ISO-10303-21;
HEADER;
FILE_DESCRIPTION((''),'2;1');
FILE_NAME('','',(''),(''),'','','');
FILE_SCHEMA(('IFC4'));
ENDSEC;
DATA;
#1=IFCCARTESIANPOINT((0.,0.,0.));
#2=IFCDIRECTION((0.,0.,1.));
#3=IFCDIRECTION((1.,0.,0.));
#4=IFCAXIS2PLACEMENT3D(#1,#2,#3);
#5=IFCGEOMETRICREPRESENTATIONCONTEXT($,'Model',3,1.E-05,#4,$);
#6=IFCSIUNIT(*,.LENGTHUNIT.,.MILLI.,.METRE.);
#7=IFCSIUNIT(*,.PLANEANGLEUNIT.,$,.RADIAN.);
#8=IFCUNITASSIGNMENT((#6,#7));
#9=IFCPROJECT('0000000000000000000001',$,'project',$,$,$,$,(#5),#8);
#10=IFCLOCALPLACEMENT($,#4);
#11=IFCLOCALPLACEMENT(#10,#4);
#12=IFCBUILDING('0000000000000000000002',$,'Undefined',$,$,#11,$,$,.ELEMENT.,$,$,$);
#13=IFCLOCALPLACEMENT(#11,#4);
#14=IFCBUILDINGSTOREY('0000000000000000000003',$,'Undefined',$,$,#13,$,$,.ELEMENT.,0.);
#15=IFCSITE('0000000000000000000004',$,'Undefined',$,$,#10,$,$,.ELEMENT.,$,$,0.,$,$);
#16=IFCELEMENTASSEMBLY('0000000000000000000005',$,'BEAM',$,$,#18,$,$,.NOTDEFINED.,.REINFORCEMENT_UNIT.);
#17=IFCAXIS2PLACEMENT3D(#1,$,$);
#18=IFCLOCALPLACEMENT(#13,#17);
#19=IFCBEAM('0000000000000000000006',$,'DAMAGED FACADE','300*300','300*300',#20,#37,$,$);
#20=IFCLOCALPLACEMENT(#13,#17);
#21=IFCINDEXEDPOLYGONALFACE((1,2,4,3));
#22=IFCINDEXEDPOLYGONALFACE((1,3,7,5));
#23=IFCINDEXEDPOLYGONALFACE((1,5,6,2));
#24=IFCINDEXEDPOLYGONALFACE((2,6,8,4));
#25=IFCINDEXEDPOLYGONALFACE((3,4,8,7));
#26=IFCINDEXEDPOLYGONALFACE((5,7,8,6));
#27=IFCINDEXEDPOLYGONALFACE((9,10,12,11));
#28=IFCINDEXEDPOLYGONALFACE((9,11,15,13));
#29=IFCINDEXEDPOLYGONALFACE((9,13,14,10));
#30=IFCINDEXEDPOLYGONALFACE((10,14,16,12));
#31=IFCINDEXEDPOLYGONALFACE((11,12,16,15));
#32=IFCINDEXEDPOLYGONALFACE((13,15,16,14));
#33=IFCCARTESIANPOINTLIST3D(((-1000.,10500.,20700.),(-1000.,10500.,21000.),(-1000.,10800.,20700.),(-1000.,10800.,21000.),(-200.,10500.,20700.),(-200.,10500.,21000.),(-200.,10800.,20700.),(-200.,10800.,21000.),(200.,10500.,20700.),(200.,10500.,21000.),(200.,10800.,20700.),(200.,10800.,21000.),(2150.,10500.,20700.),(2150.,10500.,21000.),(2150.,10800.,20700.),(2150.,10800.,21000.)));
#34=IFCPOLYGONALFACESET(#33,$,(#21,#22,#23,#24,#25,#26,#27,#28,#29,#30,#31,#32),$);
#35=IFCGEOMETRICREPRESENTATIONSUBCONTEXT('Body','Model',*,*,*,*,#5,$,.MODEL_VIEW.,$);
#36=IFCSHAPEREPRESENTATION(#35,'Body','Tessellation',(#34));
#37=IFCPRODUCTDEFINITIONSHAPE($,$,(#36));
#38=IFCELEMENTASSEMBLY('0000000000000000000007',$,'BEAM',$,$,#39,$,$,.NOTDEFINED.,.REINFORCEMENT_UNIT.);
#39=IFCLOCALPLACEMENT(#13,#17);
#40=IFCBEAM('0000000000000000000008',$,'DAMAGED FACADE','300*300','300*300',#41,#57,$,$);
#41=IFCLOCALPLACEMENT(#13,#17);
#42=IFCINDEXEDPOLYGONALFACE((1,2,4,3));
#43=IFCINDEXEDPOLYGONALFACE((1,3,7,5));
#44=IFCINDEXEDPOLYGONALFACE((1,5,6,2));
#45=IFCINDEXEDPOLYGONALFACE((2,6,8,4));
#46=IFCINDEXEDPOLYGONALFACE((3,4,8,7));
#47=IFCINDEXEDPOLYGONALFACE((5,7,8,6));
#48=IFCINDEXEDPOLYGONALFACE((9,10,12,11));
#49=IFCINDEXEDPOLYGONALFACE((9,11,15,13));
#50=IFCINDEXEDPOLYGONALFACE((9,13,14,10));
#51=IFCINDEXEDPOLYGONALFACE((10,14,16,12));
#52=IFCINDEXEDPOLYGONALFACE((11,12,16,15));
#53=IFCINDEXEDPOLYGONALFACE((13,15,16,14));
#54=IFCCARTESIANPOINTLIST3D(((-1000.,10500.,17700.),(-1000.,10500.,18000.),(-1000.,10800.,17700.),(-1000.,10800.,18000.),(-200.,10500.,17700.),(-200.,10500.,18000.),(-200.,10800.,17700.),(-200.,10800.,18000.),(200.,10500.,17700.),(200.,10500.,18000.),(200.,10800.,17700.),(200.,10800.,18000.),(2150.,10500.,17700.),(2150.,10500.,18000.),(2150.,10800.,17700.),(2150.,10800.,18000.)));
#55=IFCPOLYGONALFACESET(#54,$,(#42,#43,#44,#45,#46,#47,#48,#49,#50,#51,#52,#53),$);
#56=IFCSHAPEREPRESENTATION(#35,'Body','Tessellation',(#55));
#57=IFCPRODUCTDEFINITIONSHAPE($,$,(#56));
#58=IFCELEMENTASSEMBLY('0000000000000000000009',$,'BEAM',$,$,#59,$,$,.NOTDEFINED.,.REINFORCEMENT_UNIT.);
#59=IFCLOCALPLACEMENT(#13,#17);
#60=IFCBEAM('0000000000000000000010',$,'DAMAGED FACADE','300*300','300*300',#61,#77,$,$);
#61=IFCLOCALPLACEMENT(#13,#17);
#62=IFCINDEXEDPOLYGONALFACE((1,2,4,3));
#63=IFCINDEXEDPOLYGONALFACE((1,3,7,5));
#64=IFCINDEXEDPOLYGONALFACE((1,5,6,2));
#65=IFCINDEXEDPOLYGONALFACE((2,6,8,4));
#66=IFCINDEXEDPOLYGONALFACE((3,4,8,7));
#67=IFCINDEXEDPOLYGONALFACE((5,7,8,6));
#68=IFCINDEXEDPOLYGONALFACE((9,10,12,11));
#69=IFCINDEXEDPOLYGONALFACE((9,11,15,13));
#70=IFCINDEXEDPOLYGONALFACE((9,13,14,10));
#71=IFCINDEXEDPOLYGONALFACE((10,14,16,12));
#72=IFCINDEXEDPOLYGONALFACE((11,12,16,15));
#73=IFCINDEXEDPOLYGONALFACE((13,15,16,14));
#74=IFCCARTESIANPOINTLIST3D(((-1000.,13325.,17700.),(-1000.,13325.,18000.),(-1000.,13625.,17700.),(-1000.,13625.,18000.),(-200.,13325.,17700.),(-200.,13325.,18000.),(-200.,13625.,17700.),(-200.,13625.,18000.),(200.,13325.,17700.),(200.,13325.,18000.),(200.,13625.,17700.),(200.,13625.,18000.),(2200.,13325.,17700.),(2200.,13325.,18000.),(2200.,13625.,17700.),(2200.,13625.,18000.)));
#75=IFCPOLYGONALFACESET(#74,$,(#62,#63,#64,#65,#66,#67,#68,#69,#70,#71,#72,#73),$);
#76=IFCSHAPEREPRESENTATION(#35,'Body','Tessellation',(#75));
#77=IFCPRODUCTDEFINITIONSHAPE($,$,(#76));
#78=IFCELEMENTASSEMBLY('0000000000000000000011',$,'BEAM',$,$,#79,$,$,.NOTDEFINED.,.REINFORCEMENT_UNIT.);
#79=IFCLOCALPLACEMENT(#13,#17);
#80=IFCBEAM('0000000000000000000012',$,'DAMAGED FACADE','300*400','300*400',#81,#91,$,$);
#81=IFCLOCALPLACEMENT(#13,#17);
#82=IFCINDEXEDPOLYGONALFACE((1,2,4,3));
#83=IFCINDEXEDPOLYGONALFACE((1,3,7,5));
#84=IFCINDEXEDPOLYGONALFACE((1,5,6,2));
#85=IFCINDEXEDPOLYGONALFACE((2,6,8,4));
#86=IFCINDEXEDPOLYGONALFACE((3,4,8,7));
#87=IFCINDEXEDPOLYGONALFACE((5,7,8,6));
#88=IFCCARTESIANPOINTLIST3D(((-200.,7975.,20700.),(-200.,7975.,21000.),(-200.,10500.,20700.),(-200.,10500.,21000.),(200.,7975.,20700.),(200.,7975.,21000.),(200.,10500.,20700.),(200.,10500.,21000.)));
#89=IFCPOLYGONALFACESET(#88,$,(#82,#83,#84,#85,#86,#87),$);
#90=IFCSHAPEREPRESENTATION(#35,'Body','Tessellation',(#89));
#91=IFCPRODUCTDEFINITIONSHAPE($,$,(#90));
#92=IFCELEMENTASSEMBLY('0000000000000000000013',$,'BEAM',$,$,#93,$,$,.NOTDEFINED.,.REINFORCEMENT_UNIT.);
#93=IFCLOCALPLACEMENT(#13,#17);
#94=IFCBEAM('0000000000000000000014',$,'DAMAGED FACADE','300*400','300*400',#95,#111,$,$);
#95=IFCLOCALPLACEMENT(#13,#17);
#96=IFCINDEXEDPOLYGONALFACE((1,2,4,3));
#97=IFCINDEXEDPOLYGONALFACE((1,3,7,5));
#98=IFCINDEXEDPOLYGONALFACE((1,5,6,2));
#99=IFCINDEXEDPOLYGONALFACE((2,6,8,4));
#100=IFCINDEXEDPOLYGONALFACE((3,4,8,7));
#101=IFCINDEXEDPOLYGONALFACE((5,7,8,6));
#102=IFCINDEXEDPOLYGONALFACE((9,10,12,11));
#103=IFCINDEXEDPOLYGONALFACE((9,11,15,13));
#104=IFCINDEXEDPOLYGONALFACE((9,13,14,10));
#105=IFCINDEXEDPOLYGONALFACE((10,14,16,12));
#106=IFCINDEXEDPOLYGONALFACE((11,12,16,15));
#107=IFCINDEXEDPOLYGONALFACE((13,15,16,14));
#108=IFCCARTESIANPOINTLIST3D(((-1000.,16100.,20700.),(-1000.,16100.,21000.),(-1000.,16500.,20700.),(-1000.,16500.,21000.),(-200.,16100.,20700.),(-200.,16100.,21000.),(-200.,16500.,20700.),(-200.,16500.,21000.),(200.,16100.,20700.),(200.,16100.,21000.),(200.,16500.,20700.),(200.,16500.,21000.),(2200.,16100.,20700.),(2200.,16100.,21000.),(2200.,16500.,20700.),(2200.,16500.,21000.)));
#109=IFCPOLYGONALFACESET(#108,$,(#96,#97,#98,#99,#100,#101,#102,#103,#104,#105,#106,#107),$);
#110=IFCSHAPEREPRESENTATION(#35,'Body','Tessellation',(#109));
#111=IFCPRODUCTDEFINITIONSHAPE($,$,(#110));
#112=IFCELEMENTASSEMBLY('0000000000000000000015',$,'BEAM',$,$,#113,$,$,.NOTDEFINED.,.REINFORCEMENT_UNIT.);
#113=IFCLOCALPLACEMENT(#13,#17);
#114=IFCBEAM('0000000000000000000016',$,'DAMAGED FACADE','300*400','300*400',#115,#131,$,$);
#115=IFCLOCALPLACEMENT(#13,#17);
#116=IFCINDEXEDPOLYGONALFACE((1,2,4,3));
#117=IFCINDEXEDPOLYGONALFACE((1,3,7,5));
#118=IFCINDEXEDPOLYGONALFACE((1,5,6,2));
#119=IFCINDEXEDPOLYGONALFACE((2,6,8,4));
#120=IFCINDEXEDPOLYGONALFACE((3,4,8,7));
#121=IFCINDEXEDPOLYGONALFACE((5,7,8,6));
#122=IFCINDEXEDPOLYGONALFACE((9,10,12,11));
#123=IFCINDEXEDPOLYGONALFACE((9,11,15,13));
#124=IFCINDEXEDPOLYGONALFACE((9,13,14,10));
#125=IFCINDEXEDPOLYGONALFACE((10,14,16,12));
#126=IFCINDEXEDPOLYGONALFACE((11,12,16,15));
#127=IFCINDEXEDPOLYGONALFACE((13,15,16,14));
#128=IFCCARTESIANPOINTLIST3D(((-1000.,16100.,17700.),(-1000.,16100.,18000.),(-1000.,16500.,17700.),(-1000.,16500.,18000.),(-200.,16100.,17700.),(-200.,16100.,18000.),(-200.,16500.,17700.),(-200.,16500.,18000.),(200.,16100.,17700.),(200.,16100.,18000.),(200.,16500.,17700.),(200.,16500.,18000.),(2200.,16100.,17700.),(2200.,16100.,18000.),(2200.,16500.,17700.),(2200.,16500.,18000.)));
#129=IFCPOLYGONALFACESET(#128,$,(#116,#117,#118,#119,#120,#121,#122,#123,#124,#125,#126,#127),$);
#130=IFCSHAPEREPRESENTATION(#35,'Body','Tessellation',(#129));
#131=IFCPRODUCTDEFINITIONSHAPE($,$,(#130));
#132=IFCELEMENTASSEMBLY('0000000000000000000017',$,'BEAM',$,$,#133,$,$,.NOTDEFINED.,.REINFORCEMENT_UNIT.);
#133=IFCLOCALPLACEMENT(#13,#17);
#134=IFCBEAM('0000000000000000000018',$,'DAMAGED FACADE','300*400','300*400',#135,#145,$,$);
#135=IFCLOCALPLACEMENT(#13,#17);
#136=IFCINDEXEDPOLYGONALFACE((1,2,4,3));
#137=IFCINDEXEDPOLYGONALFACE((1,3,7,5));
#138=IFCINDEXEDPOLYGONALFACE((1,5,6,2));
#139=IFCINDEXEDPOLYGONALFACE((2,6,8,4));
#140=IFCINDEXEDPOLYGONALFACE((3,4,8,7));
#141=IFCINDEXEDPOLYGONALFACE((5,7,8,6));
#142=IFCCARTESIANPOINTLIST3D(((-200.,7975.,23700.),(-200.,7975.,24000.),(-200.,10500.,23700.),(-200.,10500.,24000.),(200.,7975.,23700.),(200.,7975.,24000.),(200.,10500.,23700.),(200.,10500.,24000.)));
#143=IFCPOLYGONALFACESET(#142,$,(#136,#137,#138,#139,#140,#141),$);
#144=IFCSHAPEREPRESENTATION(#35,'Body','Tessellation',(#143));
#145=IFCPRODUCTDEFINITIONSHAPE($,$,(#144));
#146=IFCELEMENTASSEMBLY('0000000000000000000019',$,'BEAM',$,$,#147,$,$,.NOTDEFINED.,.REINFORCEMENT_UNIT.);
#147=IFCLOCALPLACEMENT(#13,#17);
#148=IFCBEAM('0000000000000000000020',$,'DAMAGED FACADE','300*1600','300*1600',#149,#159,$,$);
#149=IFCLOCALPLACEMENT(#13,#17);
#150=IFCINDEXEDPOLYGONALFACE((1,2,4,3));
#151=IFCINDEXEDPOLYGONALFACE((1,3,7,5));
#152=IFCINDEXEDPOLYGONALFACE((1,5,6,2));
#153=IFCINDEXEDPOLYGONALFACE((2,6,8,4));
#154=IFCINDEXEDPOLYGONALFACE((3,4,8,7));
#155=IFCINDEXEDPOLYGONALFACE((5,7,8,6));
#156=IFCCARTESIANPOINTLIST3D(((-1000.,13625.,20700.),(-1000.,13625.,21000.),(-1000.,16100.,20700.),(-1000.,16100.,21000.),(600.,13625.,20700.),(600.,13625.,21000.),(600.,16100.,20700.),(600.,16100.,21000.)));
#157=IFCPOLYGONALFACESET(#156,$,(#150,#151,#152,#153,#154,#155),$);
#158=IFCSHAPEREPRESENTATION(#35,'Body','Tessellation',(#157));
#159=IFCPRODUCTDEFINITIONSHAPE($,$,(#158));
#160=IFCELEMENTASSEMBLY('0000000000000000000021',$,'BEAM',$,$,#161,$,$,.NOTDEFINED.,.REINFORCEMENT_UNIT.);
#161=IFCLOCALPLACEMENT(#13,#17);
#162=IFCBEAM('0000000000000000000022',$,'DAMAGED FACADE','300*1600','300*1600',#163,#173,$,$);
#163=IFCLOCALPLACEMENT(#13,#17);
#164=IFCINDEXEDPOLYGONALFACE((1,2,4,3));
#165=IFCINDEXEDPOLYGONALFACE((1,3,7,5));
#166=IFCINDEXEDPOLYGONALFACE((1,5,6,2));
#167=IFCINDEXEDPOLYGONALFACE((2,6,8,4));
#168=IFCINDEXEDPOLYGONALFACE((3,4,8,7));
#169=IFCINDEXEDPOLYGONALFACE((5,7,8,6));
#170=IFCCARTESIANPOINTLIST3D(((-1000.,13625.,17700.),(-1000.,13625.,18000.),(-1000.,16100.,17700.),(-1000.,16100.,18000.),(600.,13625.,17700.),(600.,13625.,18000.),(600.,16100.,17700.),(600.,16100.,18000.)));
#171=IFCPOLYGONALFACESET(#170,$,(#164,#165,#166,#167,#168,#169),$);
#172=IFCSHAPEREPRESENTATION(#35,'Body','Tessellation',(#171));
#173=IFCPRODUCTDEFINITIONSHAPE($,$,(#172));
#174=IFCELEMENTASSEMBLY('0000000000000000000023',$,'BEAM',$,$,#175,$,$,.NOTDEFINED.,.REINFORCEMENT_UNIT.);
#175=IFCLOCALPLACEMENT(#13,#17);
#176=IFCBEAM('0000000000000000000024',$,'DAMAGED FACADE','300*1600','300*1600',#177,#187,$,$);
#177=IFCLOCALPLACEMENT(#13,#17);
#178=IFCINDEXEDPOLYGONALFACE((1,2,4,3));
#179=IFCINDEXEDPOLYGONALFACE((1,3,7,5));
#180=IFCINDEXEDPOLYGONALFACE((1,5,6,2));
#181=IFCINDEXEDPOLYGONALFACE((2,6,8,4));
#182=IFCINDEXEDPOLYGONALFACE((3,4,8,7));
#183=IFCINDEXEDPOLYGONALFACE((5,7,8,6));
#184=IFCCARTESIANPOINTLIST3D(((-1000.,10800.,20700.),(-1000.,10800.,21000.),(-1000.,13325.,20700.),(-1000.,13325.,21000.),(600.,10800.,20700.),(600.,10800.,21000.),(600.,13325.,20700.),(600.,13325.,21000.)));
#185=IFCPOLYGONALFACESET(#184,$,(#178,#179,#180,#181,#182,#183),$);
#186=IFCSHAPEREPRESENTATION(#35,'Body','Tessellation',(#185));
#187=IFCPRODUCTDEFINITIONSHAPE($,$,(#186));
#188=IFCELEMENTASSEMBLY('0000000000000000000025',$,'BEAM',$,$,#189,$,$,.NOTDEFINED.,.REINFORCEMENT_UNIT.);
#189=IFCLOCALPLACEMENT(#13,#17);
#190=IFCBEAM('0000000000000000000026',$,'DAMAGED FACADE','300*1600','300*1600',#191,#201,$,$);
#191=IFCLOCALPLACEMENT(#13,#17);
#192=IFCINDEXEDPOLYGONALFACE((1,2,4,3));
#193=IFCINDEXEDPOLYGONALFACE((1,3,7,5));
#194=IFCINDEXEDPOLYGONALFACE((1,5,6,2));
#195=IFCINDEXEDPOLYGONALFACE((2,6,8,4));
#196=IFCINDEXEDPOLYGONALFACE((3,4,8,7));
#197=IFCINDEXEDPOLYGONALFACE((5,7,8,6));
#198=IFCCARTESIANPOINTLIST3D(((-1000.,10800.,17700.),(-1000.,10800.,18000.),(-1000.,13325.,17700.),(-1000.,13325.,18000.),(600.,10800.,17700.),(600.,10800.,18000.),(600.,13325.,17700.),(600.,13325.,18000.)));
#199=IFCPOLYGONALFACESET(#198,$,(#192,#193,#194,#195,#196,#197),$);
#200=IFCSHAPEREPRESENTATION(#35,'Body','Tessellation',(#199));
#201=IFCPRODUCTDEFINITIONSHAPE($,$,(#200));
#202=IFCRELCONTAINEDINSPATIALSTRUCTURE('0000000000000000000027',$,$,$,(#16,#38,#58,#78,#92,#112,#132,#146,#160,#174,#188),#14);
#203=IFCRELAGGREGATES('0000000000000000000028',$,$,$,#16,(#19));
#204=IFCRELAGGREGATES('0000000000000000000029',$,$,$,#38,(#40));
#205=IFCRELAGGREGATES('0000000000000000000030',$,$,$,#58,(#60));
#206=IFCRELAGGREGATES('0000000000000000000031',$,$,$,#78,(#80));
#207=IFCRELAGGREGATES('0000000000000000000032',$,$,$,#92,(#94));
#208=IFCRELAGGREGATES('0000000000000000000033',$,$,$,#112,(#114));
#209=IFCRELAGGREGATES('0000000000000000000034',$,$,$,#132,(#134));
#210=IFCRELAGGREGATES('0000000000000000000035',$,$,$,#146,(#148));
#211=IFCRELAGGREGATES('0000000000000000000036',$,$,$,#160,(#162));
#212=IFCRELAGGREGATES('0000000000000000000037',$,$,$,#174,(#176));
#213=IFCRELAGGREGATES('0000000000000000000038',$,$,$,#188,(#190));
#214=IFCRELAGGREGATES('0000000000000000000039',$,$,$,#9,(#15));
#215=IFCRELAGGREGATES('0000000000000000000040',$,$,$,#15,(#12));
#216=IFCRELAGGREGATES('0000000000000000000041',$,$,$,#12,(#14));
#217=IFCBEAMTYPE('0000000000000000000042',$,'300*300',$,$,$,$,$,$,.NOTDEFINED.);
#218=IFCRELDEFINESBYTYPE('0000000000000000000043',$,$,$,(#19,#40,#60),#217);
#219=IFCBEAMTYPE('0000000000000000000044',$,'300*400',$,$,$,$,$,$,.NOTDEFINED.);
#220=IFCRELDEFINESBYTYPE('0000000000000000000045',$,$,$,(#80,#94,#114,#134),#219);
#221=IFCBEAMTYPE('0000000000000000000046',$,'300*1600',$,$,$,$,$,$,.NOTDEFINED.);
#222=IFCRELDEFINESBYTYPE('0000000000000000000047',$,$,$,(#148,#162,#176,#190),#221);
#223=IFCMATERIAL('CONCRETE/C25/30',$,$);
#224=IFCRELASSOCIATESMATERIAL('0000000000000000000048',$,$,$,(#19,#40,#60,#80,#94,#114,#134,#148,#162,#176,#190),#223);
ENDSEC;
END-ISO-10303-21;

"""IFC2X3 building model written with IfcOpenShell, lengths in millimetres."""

from ifc_helpers import new_model, si_unit, frame, origin_with_axes, origin_2d_with_axis, place, context, subcontext, project, spatial, rectangle, extrude, boolean, material, type_object, element, aggregate, save


model = new_model("IFC2X3")

# Units and contexts
model_context = context("Model", 3, precision=1e-05, world=origin_with_axes())
body_context = subcontext(model_context, "Body", "Model", "MODEL_VIEW")
ifc_project = project(units=[si_unit("LENGTHUNIT", "METRE", prefix="MILLI"), si_unit("PLANEANGLEUNIT", "RADIAN")], contexts=[model_context])

# Site, building, storey
site_placement = place(None, origin_with_axes())
site = spatial("IfcSite", under=ifc_project, at=site_placement, Name="Undefined", CompositionType="ELEMENT", RefElevation=0.0)
building_placement = place(site_placement, origin_with_axes())
building = spatial("IfcBuilding", under=site, at=building_placement, Name="Undefined", CompositionType="ELEMENT")
storey_placement = place(building_placement, origin_with_axes())
storey = spatial("IfcBuildingStorey", under=building, at=storey_placement, Name="Undefined", CompositionType="ELEMENT", Elevation=0.0)

# Shared definitions
ifc_material = material(Name="CONCRETE/C25/30")

# Element assemblies, beams
beam_type_1 = type_object("IfcBeamType", Name="300*300", PredefinedType="NOTDEFINED")
assembly_1_placement = place(storey_placement, origin_with_axes())
assembly_1 = element("IfcElementAssembly", 1, at=assembly_1_placement, inside=storey, Name="BEAM", AssemblyPlace="NOTDEFINED", PredefinedType="REINFORCEMENT_UNIT")
beam_1_placement = place(assembly_1_placement, frame((2150.0, 10650.0, 20850.0), z_axis=(0.0, 0.0, 1.0), x_axis=(-1.0, 0.0, 0.0)))
beam_1 = element("IfcBeam", 2, at=beam_1_placement, type_object=beam_type_1, material=ifc_material, Name="DAMAGED FACADE", Description="300*300", ObjectType="300*300", context=body_context, shape_type="CSG", body=[
    boolean("DIFFERENCE", extrude(rectangle(XDim=300.0, YDim=300.0, at=origin_2d_with_axis()), frame((3150.0, 0.0, 0.0), z_axis=(-1.0, 0.0, 0.0), x_axis=(0.0, -1.0, 0.0)), (0.0, 0.0, 1.0), 3150.0), extrude(rectangle(XDim=400.0, YDim=300.0, at=origin_2d_with_axis()), frame((2150.0, 0.0, 150.0), z_axis=(0.0, 0.0, -1.0), x_axis=(1.0, 0.0, 0.0)), (0.0, 0.0, 1.0), 3000.0)),
])
aggregate(assembly_1, [beam_1])
assembly_2_placement = place(storey_placement, origin_with_axes())
assembly_2 = element("IfcElementAssembly", 3, at=assembly_2_placement, inside=storey, Name="BEAM", AssemblyPlace="NOTDEFINED", PredefinedType="REINFORCEMENT_UNIT")
beam_2_placement = place(assembly_2_placement, frame((2150.0, 10650.0, 17850.0), z_axis=(0.0, 0.0, 1.0), x_axis=(-1.0, 0.0, 0.0)))
beam_2 = element("IfcBeam", 4, at=beam_2_placement, type_object=beam_type_1, material=ifc_material, Name="DAMAGED FACADE", Description="300*300", ObjectType="300*300", context=body_context, shape_type="CSG", body=[
    boolean("DIFFERENCE", extrude(rectangle(XDim=300.0, YDim=300.0, at=origin_2d_with_axis()), frame((3150.0, 0.0, 0.0), z_axis=(-1.0, 0.0, 0.0), x_axis=(0.0, -1.0, 0.0)), (0.0, 0.0, 1.0), 3150.0), extrude(rectangle(XDim=400.0, YDim=300.0, at=origin_2d_with_axis()), frame((2150.0, 0.0, 150.0), z_axis=(0.0, 0.0, -1.0), x_axis=(1.0, 0.0, 0.0)), (0.0, 0.0, 1.0), 3000.0)),
])
aggregate(assembly_2, [beam_2])
assembly_3_placement = place(storey_placement, origin_with_axes())
assembly_3 = element("IfcElementAssembly", 5, at=assembly_3_placement, inside=storey, Name="BEAM", AssemblyPlace="NOTDEFINED", PredefinedType="REINFORCEMENT_UNIT")
beam_3_placement = place(assembly_3_placement, frame((2200.0, 13475.0, 17850.0), z_axis=(0.0, 0.0, 1.0), x_axis=(-1.0, 0.0, 0.0)))
beam_3 = element("IfcBeam", 6, at=beam_3_placement, type_object=beam_type_1, material=ifc_material, Name="DAMAGED FACADE", Description="300*300", ObjectType="300*300", context=body_context, shape_type="CSG", body=[
    boolean("DIFFERENCE", extrude(rectangle(XDim=300.0, YDim=300.0, at=origin_2d_with_axis()), frame((3200.0, 0.0, 0.0), z_axis=(-1.0, 0.0, 0.0), x_axis=(0.0, -1.0, 0.0)), (0.0, 0.0, 1.0), 3200.0), extrude(rectangle(XDim=400.0, YDim=300.0, at=origin_2d_with_axis()), frame((2200.0, 0.0, 150.0), z_axis=(0.0, 0.0, -1.0), x_axis=(1.0, 0.0, 0.0)), (0.0, 0.0, 1.0), 3000.0)),
])
aggregate(assembly_3, [beam_3])
beam_type_2 = type_object("IfcBeamType", Name="300*400", PredefinedType="NOTDEFINED")
assembly_4_placement = place(storey_placement, origin_with_axes())
assembly_4 = element("IfcElementAssembly", 7, at=assembly_4_placement, inside=storey, Name="BEAM", AssemblyPlace="NOTDEFINED", PredefinedType="REINFORCEMENT_UNIT")
beam_4_placement = place(assembly_4_placement, frame((0.0, 10500.0, 20850.0), z_axis=(0.0, 0.0, 1.0), x_axis=(0.0, -1.0, 0.0)))
beam_4 = element("IfcBeam", 8, at=beam_4_placement, type_object=beam_type_2, material=ifc_material, Name="DAMAGED FACADE", Description="300*400", ObjectType="300*400", context=body_context, shape_type="SweptSolid", body=[
    extrude(rectangle(XDim=400.0, YDim=300.0, at=origin_2d_with_axis()), frame((2525.0, 0.0, 0.0), z_axis=(-1.0, 0.0, 0.0), x_axis=(0.0, -1.0, 0.0)), (0.0, 0.0, 1.0), 2525.0),
])
aggregate(assembly_4, [beam_4])
assembly_5_placement = place(storey_placement, origin_with_axes())
assembly_5 = element("IfcElementAssembly", 9, at=assembly_5_placement, inside=storey, Name="BEAM", AssemblyPlace="NOTDEFINED", PredefinedType="REINFORCEMENT_UNIT")
beam_5_placement = place(assembly_5_placement, frame((2200.0, 16300.0, 20850.0), z_axis=(0.0, 0.0, 1.0), x_axis=(-1.0, 0.0, 0.0)))
beam_5 = element("IfcBeam", 10, at=beam_5_placement, type_object=beam_type_2, material=ifc_material, Name="DAMAGED FACADE", Description="300*400", ObjectType="300*400", context=body_context, shape_type="CSG", body=[
    boolean("DIFFERENCE", extrude(rectangle(XDim=400.0, YDim=300.0, at=origin_2d_with_axis()), frame((3200.0, 0.0, 0.0), z_axis=(-1.0, 0.0, 0.0), x_axis=(0.0, -1.0, 0.0)), (0.0, 0.0, 1.0), 3200.0), extrude(rectangle(XDim=400.0, YDim=400.0, at=origin_2d_with_axis()), frame((2200.0, 0.0, 150.0), z_axis=(0.0, 0.0, -1.0), x_axis=(1.0, 0.0, 0.0)), (0.0, 0.0, 1.0), 3000.0)),
])
aggregate(assembly_5, [beam_5])
assembly_6_placement = place(storey_placement, origin_with_axes())
assembly_6 = element("IfcElementAssembly", 11, at=assembly_6_placement, inside=storey, Name="BEAM", AssemblyPlace="NOTDEFINED", PredefinedType="REINFORCEMENT_UNIT")
beam_6_placement = place(assembly_6_placement, frame((2200.0, 16300.0, 17850.0), z_axis=(0.0, 0.0, 1.0), x_axis=(-1.0, 0.0, 0.0)))
beam_6 = element("IfcBeam", 12, at=beam_6_placement, type_object=beam_type_2, material=ifc_material, Name="DAMAGED FACADE", Description="300*400", ObjectType="300*400", context=body_context, shape_type="CSG", body=[
    boolean("DIFFERENCE", extrude(rectangle(XDim=400.0, YDim=300.0, at=origin_2d_with_axis()), frame((3200.0, 0.0, 0.0), z_axis=(-1.0, 0.0, 0.0), x_axis=(0.0, -1.0, 0.0)), (0.0, 0.0, 1.0), 3200.0), extrude(rectangle(XDim=400.0, YDim=400.0, at=origin_2d_with_axis()), frame((2200.0, 0.0, 150.0), z_axis=(0.0, 0.0, -1.0), x_axis=(1.0, 0.0, 0.0)), (0.0, 0.0, 1.0), 3000.0)),
])
aggregate(assembly_6, [beam_6])
assembly_7_placement = place(storey_placement, origin_with_axes())
assembly_7 = element("IfcElementAssembly", 13, at=assembly_7_placement, inside=storey, Name="BEAM", AssemblyPlace="NOTDEFINED", PredefinedType="REINFORCEMENT_UNIT")
beam_7_placement = place(assembly_7_placement, frame((0.0, 10500.0, 23850.0), z_axis=(0.0, 0.0, 1.0), x_axis=(0.0, -1.0, 0.0)))
beam_7 = element("IfcBeam", 14, at=beam_7_placement, type_object=beam_type_2, material=ifc_material, Name="DAMAGED FACADE", Description="300*400", ObjectType="300*400", context=body_context, shape_type="SweptSolid", body=[
    extrude(rectangle(XDim=400.0, YDim=300.0, at=origin_2d_with_axis()), frame((2525.0, 0.0, 0.0), z_axis=(-1.0, 0.0, 0.0), x_axis=(0.0, -1.0, 0.0)), (0.0, 0.0, 1.0), 2525.0),
])
aggregate(assembly_7, [beam_7])
assembly_8_placement = place(storey_placement, origin_with_axes())
assembly_8 = element("IfcElementAssembly", 15, at=assembly_8_placement, inside=storey, Name="BEAM", AssemblyPlace="NOTDEFINED", PredefinedType="REINFORCEMENT_UNIT")
beam_type_3 = type_object("IfcBeamType", Name="300*1600", PredefinedType="NOTDEFINED")
beam_8_placement = place(assembly_8_placement, frame((-200.0, 13625.0, 20850.0), z_axis=(0.0, 0.0, 1.0), x_axis=(0.0, 1.0, 0.0)))
beam_8 = element("IfcBeam", 16, at=beam_8_placement, type_object=beam_type_3, material=ifc_material, Name="DAMAGED FACADE", Description="300*1600", ObjectType="300*1600", context=body_context, shape_type="SweptSolid", body=[
    extrude(rectangle(XDim=1600.0, YDim=300.0, at=origin_2d_with_axis()), frame((2475.0, 0.0, 0.0), z_axis=(-1.0, 0.0, 0.0), x_axis=(0.0, -1.0, 0.0)), (0.0, 0.0, 1.0), 2475.0),
])
aggregate(assembly_8, [beam_8])
assembly_9_placement = place(storey_placement, origin_with_axes())
assembly_9 = element("IfcElementAssembly", 17, at=assembly_9_placement, inside=storey, Name="BEAM", AssemblyPlace="NOTDEFINED", PredefinedType="REINFORCEMENT_UNIT")
beam_9_placement = place(assembly_9_placement, frame((-200.0, 13625.0, 17850.0), z_axis=(0.0, 0.0, 1.0), x_axis=(0.0, 1.0, 0.0)))
beam_9 = element("IfcBeam", 18, at=beam_9_placement, type_object=beam_type_3, material=ifc_material, Name="DAMAGED FACADE", Description="300*1600", ObjectType="300*1600", context=body_context, shape_type="SweptSolid", body=[
    extrude(rectangle(XDim=1600.0, YDim=300.0, at=origin_2d_with_axis()), frame((2475.0, 0.0, 0.0), z_axis=(-1.0, 0.0, 0.0), x_axis=(0.0, -1.0, 0.0)), (0.0, 0.0, 1.0), 2475.0),
])
aggregate(assembly_9, [beam_9])
assembly_10_placement = place(storey_placement, origin_with_axes())
assembly_10 = element("IfcElementAssembly", 19, at=assembly_10_placement, inside=storey, Name="BEAM", AssemblyPlace="NOTDEFINED", PredefinedType="REINFORCEMENT_UNIT")
beam_10_placement = place(assembly_10_placement, frame((-200.0, 13325.0, 20850.0), z_axis=(0.0, 0.0, 1.0), x_axis=(0.0, -1.0, 0.0)))
beam_10 = element("IfcBeam", 20, at=beam_10_placement, type_object=beam_type_3, material=ifc_material, Name="DAMAGED FACADE", Description="300*1600", ObjectType="300*1600", context=body_context, shape_type="SweptSolid", body=[
    extrude(rectangle(XDim=1600.0, YDim=300.0, at=origin_2d_with_axis()), frame((2525.0, 0.0, 0.0), z_axis=(-1.0, 0.0, 0.0), x_axis=(0.0, -1.0, 0.0)), (0.0, 0.0, 1.0), 2525.0),
])
aggregate(assembly_10, [beam_10])
assembly_11_placement = place(storey_placement, origin_with_axes())
assembly_11 = element("IfcElementAssembly", 21, at=assembly_11_placement, inside=storey, Name="BEAM", AssemblyPlace="NOTDEFINED", PredefinedType="REINFORCEMENT_UNIT")
beam_11_placement = place(assembly_11_placement, frame((-200.0, 13325.0, 17850.0), z_axis=(0.0, 0.0, 1.0), x_axis=(0.0, -1.0, 0.0)))
beam_11 = element("IfcBeam", 22, at=beam_11_placement, type_object=beam_type_3, material=ifc_material, Name="DAMAGED FACADE", Description="300*1600", ObjectType="300*1600", context=body_context, shape_type="SweptSolid", body=[
    extrude(rectangle(XDim=1600.0, YDim=300.0, at=origin_2d_with_axis()), frame((2525.0, 0.0, 0.0), z_axis=(-1.0, 0.0, 0.0), x_axis=(0.0, -1.0, 0.0)), (0.0, 0.0, 1.0), 2525.0),
])
aggregate(assembly_11, [beam_11])

save(model, "model.ifc")
